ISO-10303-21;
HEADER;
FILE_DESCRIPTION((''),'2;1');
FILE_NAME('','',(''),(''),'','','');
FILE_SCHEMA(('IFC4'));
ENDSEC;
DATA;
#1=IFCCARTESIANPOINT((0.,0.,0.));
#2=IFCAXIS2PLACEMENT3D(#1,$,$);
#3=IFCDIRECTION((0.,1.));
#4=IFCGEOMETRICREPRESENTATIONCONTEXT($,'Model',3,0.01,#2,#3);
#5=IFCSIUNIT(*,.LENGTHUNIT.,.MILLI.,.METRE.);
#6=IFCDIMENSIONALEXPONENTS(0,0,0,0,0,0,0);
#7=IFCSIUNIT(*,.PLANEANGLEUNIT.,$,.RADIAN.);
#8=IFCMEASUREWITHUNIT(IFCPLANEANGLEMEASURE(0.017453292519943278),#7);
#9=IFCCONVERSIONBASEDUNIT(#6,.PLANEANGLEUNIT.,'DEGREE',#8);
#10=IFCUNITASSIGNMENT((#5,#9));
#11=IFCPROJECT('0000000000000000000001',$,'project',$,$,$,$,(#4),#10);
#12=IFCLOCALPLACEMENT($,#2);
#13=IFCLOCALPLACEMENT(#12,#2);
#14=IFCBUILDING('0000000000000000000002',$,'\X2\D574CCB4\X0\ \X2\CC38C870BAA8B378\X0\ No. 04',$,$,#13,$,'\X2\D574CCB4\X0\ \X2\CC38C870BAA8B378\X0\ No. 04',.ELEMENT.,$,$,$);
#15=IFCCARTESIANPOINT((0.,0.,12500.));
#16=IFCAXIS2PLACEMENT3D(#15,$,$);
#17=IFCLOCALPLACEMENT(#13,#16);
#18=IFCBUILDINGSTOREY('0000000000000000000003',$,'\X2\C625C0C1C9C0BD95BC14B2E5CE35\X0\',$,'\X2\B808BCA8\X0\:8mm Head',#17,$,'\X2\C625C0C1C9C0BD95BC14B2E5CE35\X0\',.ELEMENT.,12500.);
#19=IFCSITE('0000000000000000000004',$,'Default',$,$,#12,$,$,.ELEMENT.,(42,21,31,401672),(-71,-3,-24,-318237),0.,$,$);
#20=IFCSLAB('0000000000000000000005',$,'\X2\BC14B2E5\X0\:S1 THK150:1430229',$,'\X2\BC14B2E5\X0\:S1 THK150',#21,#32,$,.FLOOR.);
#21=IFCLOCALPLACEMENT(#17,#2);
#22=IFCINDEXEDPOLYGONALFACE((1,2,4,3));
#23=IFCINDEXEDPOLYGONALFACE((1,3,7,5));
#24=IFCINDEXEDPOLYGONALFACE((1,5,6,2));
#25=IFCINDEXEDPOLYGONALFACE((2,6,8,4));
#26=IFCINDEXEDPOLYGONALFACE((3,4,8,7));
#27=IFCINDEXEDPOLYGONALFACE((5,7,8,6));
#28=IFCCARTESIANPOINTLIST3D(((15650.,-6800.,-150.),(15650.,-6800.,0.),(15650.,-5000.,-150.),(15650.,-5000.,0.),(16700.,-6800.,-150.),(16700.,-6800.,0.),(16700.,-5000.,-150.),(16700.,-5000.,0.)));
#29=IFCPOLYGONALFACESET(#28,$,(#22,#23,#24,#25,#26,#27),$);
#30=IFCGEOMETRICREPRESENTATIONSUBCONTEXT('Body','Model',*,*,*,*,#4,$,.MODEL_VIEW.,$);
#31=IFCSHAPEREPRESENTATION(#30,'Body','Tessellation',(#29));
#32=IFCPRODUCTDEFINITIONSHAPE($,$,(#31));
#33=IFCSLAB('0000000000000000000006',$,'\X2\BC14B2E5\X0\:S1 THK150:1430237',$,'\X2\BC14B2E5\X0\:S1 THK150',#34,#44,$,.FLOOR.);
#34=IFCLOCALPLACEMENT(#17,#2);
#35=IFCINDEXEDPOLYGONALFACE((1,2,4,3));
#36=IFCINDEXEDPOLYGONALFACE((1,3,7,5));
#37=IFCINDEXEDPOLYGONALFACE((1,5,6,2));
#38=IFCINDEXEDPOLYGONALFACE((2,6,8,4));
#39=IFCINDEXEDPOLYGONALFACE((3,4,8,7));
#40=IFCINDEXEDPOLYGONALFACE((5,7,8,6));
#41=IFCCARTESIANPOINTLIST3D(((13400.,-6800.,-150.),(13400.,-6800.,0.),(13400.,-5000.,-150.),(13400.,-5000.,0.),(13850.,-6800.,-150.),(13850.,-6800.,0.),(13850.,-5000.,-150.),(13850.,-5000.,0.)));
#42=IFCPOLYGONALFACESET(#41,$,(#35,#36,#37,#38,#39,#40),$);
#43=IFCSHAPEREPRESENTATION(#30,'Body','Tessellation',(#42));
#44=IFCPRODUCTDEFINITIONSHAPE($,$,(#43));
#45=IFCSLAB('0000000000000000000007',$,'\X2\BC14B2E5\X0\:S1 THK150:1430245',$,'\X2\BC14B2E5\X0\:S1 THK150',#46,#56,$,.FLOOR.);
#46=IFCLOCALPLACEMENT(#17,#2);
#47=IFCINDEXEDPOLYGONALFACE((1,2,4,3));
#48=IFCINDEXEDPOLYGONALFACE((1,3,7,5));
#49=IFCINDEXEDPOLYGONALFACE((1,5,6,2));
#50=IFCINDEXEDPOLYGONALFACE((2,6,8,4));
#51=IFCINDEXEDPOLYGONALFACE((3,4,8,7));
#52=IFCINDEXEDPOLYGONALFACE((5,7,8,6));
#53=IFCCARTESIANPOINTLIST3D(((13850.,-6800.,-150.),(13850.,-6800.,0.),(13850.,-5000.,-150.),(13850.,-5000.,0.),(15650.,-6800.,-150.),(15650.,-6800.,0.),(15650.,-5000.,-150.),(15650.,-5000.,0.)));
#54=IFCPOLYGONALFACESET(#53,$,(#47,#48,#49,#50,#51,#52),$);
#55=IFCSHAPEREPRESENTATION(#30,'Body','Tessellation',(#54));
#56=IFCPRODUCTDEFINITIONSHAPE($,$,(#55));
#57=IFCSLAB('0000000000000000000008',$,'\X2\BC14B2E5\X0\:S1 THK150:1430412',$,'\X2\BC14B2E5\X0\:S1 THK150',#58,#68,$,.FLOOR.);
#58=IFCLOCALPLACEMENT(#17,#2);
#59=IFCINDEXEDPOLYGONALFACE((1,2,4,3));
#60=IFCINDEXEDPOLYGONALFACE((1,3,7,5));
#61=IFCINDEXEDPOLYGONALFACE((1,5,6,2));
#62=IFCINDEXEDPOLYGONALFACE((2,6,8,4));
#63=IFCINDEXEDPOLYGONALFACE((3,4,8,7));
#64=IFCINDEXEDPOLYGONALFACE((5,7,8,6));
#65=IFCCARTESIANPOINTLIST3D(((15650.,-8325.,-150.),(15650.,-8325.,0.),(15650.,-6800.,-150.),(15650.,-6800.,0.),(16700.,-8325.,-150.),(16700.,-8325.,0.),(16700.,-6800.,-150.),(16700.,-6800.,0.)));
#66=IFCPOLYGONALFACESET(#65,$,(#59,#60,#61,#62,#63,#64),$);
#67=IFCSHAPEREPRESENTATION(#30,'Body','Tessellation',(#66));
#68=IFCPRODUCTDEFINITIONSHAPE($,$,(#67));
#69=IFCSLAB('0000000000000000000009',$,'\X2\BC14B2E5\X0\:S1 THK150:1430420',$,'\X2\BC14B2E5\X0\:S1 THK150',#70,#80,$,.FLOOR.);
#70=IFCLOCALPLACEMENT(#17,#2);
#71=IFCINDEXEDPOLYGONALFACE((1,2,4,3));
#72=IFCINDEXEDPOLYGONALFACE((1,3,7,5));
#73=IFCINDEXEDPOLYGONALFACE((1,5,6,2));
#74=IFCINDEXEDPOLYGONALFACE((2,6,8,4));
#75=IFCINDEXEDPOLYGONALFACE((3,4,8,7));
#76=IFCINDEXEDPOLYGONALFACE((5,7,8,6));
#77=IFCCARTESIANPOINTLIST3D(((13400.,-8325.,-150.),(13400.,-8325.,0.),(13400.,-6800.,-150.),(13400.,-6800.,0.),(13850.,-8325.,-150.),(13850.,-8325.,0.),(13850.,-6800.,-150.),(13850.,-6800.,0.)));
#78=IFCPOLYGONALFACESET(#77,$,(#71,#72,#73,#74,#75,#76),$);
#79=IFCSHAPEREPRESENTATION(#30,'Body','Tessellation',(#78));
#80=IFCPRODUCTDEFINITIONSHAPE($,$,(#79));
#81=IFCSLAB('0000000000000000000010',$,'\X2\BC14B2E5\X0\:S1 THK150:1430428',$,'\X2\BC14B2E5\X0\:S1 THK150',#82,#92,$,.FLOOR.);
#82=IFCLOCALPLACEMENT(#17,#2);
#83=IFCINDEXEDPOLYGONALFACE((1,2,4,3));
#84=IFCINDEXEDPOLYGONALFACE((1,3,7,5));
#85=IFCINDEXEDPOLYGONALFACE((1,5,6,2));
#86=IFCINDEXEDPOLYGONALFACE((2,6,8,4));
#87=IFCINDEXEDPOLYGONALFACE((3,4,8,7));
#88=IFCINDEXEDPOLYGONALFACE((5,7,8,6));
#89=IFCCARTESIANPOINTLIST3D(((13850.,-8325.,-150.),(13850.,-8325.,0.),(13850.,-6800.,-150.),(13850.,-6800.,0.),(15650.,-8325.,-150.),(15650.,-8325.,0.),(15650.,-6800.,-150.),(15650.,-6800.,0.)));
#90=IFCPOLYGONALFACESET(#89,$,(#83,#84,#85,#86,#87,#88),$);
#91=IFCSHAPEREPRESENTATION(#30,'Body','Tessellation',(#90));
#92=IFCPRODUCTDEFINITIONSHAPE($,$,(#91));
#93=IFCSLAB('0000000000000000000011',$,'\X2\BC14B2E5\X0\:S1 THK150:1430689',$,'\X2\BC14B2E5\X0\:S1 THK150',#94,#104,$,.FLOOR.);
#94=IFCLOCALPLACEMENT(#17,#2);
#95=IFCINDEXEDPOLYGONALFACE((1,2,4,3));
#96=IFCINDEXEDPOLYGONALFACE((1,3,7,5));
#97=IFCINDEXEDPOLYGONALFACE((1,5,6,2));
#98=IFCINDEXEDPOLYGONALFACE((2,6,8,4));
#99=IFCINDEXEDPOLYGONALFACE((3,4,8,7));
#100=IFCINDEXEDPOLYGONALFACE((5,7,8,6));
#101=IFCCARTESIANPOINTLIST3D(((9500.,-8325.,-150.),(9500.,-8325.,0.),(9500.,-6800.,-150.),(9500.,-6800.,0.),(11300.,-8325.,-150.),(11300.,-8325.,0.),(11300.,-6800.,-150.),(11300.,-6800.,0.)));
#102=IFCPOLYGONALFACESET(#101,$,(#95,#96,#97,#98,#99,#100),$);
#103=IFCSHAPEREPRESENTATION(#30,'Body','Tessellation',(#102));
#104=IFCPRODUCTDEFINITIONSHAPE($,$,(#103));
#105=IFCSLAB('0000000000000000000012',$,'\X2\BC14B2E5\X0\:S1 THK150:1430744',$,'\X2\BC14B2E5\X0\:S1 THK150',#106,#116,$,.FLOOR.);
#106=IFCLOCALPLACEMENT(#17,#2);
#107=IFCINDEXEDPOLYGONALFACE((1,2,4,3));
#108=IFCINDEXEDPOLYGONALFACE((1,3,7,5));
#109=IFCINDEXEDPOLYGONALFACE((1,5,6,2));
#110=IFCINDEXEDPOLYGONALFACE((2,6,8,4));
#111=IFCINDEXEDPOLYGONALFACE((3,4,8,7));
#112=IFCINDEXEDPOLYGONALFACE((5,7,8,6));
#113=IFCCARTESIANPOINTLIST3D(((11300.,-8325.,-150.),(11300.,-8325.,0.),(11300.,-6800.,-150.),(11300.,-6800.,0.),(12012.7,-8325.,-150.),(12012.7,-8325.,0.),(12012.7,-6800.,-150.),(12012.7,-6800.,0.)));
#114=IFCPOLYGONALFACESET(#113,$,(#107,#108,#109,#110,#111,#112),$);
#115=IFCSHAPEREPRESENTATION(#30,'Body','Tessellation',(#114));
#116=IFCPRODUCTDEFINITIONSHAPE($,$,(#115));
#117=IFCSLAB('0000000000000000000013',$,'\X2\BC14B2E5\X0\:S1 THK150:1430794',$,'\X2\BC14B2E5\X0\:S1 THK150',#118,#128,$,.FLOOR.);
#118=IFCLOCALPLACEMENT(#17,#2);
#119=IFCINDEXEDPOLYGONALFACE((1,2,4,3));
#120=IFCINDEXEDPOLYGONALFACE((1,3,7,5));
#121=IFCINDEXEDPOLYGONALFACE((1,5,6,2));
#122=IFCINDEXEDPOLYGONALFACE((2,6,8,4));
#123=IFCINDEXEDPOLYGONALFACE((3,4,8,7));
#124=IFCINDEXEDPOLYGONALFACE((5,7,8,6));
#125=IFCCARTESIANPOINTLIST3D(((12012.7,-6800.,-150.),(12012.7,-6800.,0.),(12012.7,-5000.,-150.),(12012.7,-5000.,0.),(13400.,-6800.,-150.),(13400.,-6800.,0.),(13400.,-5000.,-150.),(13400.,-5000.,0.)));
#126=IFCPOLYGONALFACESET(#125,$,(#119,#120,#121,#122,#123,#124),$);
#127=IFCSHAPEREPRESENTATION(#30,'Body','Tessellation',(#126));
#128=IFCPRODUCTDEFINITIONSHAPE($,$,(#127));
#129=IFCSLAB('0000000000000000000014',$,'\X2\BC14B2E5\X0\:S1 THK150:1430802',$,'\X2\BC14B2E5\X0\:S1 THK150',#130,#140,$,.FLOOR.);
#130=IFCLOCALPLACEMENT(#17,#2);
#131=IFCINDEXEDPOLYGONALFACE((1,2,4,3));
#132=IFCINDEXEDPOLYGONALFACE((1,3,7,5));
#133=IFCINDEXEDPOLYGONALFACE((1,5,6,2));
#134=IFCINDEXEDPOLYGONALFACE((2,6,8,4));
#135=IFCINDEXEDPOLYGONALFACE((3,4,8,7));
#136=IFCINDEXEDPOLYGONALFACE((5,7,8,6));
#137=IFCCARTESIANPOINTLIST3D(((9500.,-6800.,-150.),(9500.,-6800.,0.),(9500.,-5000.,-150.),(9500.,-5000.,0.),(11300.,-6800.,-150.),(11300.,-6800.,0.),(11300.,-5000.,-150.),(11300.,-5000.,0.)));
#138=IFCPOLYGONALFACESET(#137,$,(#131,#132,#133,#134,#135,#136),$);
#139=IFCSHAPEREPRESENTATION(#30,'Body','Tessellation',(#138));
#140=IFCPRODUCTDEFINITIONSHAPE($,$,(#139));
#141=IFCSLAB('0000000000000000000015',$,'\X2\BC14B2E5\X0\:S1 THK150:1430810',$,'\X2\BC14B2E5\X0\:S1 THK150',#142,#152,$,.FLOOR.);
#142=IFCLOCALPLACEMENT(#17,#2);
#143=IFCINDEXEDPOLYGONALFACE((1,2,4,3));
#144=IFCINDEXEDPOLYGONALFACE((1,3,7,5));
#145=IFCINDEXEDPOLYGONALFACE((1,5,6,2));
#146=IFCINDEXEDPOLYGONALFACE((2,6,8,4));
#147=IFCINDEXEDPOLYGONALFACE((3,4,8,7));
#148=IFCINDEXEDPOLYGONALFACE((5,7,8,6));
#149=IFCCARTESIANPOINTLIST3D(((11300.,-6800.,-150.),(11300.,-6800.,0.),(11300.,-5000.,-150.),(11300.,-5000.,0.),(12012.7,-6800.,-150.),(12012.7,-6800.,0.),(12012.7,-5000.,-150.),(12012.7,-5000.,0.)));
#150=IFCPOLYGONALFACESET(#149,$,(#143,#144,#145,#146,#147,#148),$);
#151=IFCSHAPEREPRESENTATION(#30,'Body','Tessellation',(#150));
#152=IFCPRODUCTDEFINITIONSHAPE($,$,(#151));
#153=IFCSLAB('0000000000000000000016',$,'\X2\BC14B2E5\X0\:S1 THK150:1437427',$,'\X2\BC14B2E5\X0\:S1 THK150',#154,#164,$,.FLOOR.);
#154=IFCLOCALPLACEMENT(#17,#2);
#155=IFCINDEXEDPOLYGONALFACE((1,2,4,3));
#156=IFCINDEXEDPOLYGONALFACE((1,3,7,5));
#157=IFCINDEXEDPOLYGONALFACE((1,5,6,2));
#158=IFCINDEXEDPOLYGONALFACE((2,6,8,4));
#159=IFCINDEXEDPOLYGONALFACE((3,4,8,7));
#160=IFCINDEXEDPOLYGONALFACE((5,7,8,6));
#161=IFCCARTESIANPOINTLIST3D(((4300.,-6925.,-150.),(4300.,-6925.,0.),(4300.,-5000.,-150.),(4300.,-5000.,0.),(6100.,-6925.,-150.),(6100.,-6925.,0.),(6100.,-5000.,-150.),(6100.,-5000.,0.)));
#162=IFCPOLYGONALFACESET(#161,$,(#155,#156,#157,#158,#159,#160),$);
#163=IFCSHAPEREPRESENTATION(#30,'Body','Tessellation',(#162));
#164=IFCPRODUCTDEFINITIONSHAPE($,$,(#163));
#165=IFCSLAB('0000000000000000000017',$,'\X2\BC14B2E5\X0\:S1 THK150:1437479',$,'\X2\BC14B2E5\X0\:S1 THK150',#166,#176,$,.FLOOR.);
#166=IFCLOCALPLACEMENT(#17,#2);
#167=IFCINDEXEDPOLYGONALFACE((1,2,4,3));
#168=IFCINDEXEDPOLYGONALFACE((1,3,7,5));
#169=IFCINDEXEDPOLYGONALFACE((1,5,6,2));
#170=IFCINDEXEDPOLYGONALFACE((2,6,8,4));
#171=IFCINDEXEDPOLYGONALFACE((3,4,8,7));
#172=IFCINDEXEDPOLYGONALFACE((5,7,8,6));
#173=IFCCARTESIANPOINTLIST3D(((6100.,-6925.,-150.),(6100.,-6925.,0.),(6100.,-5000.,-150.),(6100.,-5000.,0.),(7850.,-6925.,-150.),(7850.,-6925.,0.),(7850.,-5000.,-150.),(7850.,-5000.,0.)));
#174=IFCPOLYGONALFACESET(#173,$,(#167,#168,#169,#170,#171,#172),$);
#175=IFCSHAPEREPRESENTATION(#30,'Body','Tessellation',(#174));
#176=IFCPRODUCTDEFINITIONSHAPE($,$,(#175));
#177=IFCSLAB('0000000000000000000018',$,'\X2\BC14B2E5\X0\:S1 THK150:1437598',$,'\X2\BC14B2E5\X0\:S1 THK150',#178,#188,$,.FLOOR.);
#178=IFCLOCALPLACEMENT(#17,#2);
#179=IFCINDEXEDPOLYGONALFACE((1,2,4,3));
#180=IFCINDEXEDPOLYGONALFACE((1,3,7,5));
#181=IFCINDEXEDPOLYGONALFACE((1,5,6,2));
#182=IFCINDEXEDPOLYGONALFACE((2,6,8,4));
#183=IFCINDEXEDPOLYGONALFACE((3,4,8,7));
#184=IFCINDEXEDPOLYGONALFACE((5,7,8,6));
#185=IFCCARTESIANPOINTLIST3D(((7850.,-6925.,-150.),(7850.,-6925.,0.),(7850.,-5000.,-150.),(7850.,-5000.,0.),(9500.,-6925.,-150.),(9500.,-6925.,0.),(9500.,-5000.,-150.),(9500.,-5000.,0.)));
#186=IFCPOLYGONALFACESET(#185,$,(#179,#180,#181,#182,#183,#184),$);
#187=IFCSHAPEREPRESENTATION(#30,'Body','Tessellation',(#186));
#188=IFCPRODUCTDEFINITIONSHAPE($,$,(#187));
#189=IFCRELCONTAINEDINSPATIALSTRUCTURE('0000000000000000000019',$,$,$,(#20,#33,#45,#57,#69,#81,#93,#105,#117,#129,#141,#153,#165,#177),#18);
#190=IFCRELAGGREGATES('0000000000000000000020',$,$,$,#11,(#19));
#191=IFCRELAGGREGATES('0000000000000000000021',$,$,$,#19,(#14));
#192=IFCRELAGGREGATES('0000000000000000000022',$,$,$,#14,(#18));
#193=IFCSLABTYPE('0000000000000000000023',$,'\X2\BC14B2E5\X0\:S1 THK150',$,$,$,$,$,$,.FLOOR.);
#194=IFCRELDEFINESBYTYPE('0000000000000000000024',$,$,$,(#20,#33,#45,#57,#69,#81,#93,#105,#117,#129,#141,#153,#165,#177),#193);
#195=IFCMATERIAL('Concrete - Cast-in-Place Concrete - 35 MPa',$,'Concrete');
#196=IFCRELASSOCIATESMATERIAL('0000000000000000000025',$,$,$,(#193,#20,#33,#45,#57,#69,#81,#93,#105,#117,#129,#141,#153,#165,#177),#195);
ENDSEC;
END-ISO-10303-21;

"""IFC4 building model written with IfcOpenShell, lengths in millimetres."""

from ifc_helpers import new_model, entity, si_unit, converted_unit, direction, frame, origin, place, context, subcontext, project, spatial, indexed_curve, outline, extrude, material, type_object, element, save


model = new_model("IFC4")

# Units and contexts
model_context = context("Model", 3, precision=0.01, world=origin(), true_north=direction((0.0, 1.0)))
body_context = subcontext(model_context, "Body", "Model", "MODEL_VIEW")
ifc_project = project(units=[si_unit("LENGTHUNIT", "METRE", prefix="MILLI"), converted_unit("PLANEANGLEUNIT", "DEGREE", entity("IfcPlaneAngleMeasure", 0.017453292519943278), si_unit("PLANEANGLEUNIT", "RADIAN"), dimensions=[0, 0, 0, 0, 0, 0, 0])], contexts=[model_context])

# Site, building, storey
site_placement = place(None, origin())
site = spatial("IfcSite", under=ifc_project, at=site_placement, Name="Default", CompositionType="ELEMENT", RefLatitude=(42, 21, 31, 401672), RefLongitude=(-71, -3, -24, -318237), RefElevation=0.0)
building_placement = place(site_placement, origin())
building = spatial("IfcBuilding", under=site, at=building_placement, Name="해체 참조모델 No. 04", LongName="해체 참조모델 No. 04", CompositionType="ELEMENT")
storey_placement = place(building_placement, frame((0.0, 0.0, 12500.0)))
storey = spatial("IfcBuildingStorey", under=building, at=storey_placement, Name="옥상지붕바닥층", ObjectType="레벨:8mm Head", LongName="옥상지붕바닥층", CompositionType="ELEMENT", Elevation=12500.0)

# Slabs
ifc_material = material(Name="Concrete - Cast-in-Place Concrete - 35 MPa", Category="Concrete")
slab_type_1 = type_object("IfcSlabType", Name="바닥:S1 THK150", PredefinedType="FLOOR", material=ifc_material)
slab_1_placement = place(storey_placement, origin())
element("IfcSlab", 1, at=slab_1_placement, inside=storey, type_object=slab_type_1, material=ifc_material, Name="바닥:S1 THK150:1430229", ObjectType="바닥:S1 THK150", PredefinedType="FLOOR", context=body_context, shape_type="SweptSolid", body=[
    extrude(outline(indexed_curve([(-900.0, -525.0), (900.0, -525.0), (900.0, 525.0), (-900.0, 525.0), (-900.0, -525.0)], self_intersect=False)), frame((16175.0, -5900.0, 0.0), z_axis=(0.0, 0.0, -1.0), x_axis=(0.0, 1.0, 0.0)), (0.0, 0.0, 1.0), 150.0),
])
slab_2_placement = place(storey_placement, origin())
element("IfcSlab", 2, at=slab_2_placement, inside=storey, type_object=slab_type_1, material=ifc_material, Name="바닥:S1 THK150:1430237", ObjectType="바닥:S1 THK150", PredefinedType="FLOOR", context=body_context, shape_type="SweptSolid", body=[
    extrude(outline(indexed_curve([(-900.0, -225.0), (900.0, -225.0), (900.0, 225.0), (-900.0, 225.0), (-900.0, -225.0)], self_intersect=False)), frame((13625.0, -5900.0, 0.0), z_axis=(0.0, 0.0, -1.0), x_axis=(0.0, 1.0, 0.0)), (0.0, 0.0, 1.0), 150.0),
])
slab_3_placement = place(storey_placement, origin())
element("IfcSlab", 3, at=slab_3_placement, inside=storey, type_object=slab_type_1, material=ifc_material, Name="바닥:S1 THK150:1430245", ObjectType="바닥:S1 THK150", PredefinedType="FLOOR", context=body_context, shape_type="SweptSolid", body=[
    extrude(outline(indexed_curve([(-900.0, -900.0), (900.0, -900.0), (900.0, 900.0), (-900.0, 900.0), (-900.0, -900.0)], self_intersect=False)), frame((14750.0, -5900.0, 0.0), z_axis=(0.0, 0.0, -1.0), x_axis=(0.0, 1.0, 0.0)), (0.0, 0.0, 1.0), 150.0),
])
slab_4_placement = place(storey_placement, origin())
element("IfcSlab", 4, at=slab_4_placement, inside=storey, type_object=slab_type_1, material=ifc_material, Name="바닥:S1 THK150:1430412", ObjectType="바닥:S1 THK150", PredefinedType="FLOOR", context=body_context, shape_type="SweptSolid", body=[
    extrude(outline(indexed_curve([(-762.5, -525.0), (762.5, -525.0), (762.5, 525.0), (-762.5, 525.0), (-762.5, -525.0)], self_intersect=False)), frame((16175.0, -7562.5, 0.0), z_axis=(0.0, 0.0, -1.0), x_axis=(0.0, 1.0, 0.0)), (0.0, 0.0, 1.0), 150.0),
])
slab_5_placement = place(storey_placement, origin())
element("IfcSlab", 5, at=slab_5_placement, inside=storey, type_object=slab_type_1, material=ifc_material, Name="바닥:S1 THK150:1430420", ObjectType="바닥:S1 THK150", PredefinedType="FLOOR", context=body_context, shape_type="SweptSolid", body=[
    extrude(outline(indexed_curve([(-762.5, -225.0), (762.5, -225.0), (762.5, 225.0), (-762.5, 225.0), (-762.5, -225.0)], self_intersect=False)), frame((13625.0, -7562.5, 0.0), z_axis=(0.0, 0.0, -1.0), x_axis=(0.0, 1.0, 0.0)), (0.0, 0.0, 1.0), 150.0),
])
slab_6_placement = place(storey_placement, origin())
element("IfcSlab", 6, at=slab_6_placement, inside=storey, type_object=slab_type_1, material=ifc_material, Name="바닥:S1 THK150:1430428", ObjectType="바닥:S1 THK150", PredefinedType="FLOOR", context=body_context, shape_type="SweptSolid", body=[
    extrude(outline(indexed_curve([(-762.5, -900.0), (762.5, -900.0), (762.5, 900.0), (-762.5, 900.0), (-762.5, -900.0)], self_intersect=False)), frame((14750.0, -7562.5, 0.0), z_axis=(0.0, 0.0, -1.0), x_axis=(0.0, 1.0, 0.0)), (0.0, 0.0, 1.0), 150.0),
])
slab_7_placement = place(storey_placement, origin())
element("IfcSlab", 7, at=slab_7_placement, inside=storey, type_object=slab_type_1, material=ifc_material, Name="바닥:S1 THK150:1430689", ObjectType="바닥:S1 THK150", PredefinedType="FLOOR", context=body_context, shape_type="SweptSolid", body=[
    extrude(outline(indexed_curve([(-762.5, -900.0), (762.5, -900.0), (762.5, 900.0), (-762.5, 900.0), (-762.5, -900.0)], self_intersect=False)), frame((10400.0, -7562.5, 0.0), z_axis=(0.0, 0.0, -1.0), x_axis=(0.0, 1.0, 0.0)), (0.0, 0.0, 1.0), 150.0),
])
slab_8_placement = place(storey_placement, origin())
element("IfcSlab", 8, at=slab_8_placement, inside=storey, type_object=slab_type_1, material=ifc_material, Name="바닥:S1 THK150:1430744", ObjectType="바닥:S1 THK150", PredefinedType="FLOOR", context=body_context, shape_type="SweptSolid", body=[
    extrude(outline(indexed_curve([(-762.5, -356.4), (762.5, -356.4), (762.5, 356.4), (-762.5, 356.4), (-762.5, -356.4)], self_intersect=False)), frame((11656.4, -7562.5, 0.0), z_axis=(0.0, 0.0, -1.0), x_axis=(0.0, 1.0, 0.0)), (0.0, 0.0, 1.0), 150.0),
])
slab_9_placement = place(storey_placement, origin())
element("IfcSlab", 9, at=slab_9_placement, inside=storey, type_object=slab_type_1, material=ifc_material, Name="바닥:S1 THK150:1430794", ObjectType="바닥:S1 THK150", PredefinedType="FLOOR", context=body_context, shape_type="SweptSolid", body=[
    extrude(outline(indexed_curve([(-900.0, -693.6), (900.0, -693.6), (900.0, 693.6), (-900.0, 693.6), (-900.0, -693.6)], self_intersect=False)), frame((12706.4, -5900.0, 0.0), z_axis=(0.0, 0.0, -1.0), x_axis=(0.0, 1.0, 0.0)), (0.0, 0.0, 1.0), 150.0),
])
slab_10_placement = place(storey_placement, origin())
element("IfcSlab", 10, at=slab_10_placement, inside=storey, type_object=slab_type_1, material=ifc_material, Name="바닥:S1 THK150:1430802", ObjectType="바닥:S1 THK150", PredefinedType="FLOOR", context=body_context, shape_type="SweptSolid", body=[
    extrude(outline(indexed_curve([(-900.0, -900.0), (900.0, -900.0), (900.0, 900.0), (-900.0, 900.0), (-900.0, -900.0)], self_intersect=False)), frame((10400.0, -5900.0, 0.0), z_axis=(0.0, 0.0, -1.0), x_axis=(0.0, 1.0, 0.0)), (0.0, 0.0, 1.0), 150.0),
])
slab_11_placement = place(storey_placement, origin())
element("IfcSlab", 11, at=slab_11_placement, inside=storey, type_object=slab_type_1, material=ifc_material, Name="바닥:S1 THK150:1430810", ObjectType="바닥:S1 THK150", PredefinedType="FLOOR", context=body_context, shape_type="SweptSolid", body=[
    extrude(outline(indexed_curve([(-900.0, -356.4), (900.0, -356.4), (900.0, 356.4), (-900.0, 356.4), (-900.0, -356.4)], self_intersect=False)), frame((11656.4, -5900.0, 0.0), z_axis=(0.0, 0.0, -1.0), x_axis=(0.0, 1.0, 0.0)), (0.0, 0.0, 1.0), 150.0),
])
slab_12_placement = place(storey_placement, origin())
element("IfcSlab", 12, at=slab_12_placement, inside=storey, type_object=slab_type_1, material=ifc_material, Name="바닥:S1 THK150:1437427", ObjectType="바닥:S1 THK150", PredefinedType="FLOOR", context=body_context, shape_type="SweptSolid", body=[
    extrude(outline(indexed_curve([(-962.5, -900.0), (962.5, -900.0), (962.5, 900.0), (-962.5, 900.0), (-962.5, -900.0)], self_intersect=False)), frame((5200.0, -5962.5, 0.0), z_axis=(0.0, 0.0, -1.0), x_axis=(0.0, 1.0, 0.0)), (0.0, 0.0, 1.0), 150.0),
])
slab_13_placement = place(storey_placement, origin())
element("IfcSlab", 13, at=slab_13_placement, inside=storey, type_object=slab_type_1, material=ifc_material, Name="바닥:S1 THK150:1437479", ObjectType="바닥:S1 THK150", PredefinedType="FLOOR", context=body_context, shape_type="SweptSolid", body=[
    extrude(outline(indexed_curve([(-962.5, -875.0), (962.5, -875.0), (962.5, 875.0), (-962.5, 875.0), (-962.5, -875.0)], self_intersect=False)), frame((6975.0, -5962.5, 0.0), z_axis=(0.0, 0.0, -1.0), x_axis=(0.0, 1.0, 0.0)), (0.0, 0.0, 1.0), 150.0),
])
slab_14_placement = place(storey_placement, origin())
element("IfcSlab", 14, at=slab_14_placement, inside=storey, type_object=slab_type_1, material=ifc_material, Name="바닥:S1 THK150:1437598", ObjectType="바닥:S1 THK150", PredefinedType="FLOOR", context=body_context, shape_type="SweptSolid", body=[
    extrude(outline(indexed_curve([(-962.5, -825.0), (962.5, -825.0), (962.5, 825.0), (-962.5, 825.0), (-962.5, -825.0)], self_intersect=False)), frame((8675.0, -5962.5, 0.0), z_axis=(0.0, 0.0, -1.0), x_axis=(0.0, 1.0, 0.0)), (0.0, 0.0, 1.0), 150.0),
])

save(model, "model.ifc")
